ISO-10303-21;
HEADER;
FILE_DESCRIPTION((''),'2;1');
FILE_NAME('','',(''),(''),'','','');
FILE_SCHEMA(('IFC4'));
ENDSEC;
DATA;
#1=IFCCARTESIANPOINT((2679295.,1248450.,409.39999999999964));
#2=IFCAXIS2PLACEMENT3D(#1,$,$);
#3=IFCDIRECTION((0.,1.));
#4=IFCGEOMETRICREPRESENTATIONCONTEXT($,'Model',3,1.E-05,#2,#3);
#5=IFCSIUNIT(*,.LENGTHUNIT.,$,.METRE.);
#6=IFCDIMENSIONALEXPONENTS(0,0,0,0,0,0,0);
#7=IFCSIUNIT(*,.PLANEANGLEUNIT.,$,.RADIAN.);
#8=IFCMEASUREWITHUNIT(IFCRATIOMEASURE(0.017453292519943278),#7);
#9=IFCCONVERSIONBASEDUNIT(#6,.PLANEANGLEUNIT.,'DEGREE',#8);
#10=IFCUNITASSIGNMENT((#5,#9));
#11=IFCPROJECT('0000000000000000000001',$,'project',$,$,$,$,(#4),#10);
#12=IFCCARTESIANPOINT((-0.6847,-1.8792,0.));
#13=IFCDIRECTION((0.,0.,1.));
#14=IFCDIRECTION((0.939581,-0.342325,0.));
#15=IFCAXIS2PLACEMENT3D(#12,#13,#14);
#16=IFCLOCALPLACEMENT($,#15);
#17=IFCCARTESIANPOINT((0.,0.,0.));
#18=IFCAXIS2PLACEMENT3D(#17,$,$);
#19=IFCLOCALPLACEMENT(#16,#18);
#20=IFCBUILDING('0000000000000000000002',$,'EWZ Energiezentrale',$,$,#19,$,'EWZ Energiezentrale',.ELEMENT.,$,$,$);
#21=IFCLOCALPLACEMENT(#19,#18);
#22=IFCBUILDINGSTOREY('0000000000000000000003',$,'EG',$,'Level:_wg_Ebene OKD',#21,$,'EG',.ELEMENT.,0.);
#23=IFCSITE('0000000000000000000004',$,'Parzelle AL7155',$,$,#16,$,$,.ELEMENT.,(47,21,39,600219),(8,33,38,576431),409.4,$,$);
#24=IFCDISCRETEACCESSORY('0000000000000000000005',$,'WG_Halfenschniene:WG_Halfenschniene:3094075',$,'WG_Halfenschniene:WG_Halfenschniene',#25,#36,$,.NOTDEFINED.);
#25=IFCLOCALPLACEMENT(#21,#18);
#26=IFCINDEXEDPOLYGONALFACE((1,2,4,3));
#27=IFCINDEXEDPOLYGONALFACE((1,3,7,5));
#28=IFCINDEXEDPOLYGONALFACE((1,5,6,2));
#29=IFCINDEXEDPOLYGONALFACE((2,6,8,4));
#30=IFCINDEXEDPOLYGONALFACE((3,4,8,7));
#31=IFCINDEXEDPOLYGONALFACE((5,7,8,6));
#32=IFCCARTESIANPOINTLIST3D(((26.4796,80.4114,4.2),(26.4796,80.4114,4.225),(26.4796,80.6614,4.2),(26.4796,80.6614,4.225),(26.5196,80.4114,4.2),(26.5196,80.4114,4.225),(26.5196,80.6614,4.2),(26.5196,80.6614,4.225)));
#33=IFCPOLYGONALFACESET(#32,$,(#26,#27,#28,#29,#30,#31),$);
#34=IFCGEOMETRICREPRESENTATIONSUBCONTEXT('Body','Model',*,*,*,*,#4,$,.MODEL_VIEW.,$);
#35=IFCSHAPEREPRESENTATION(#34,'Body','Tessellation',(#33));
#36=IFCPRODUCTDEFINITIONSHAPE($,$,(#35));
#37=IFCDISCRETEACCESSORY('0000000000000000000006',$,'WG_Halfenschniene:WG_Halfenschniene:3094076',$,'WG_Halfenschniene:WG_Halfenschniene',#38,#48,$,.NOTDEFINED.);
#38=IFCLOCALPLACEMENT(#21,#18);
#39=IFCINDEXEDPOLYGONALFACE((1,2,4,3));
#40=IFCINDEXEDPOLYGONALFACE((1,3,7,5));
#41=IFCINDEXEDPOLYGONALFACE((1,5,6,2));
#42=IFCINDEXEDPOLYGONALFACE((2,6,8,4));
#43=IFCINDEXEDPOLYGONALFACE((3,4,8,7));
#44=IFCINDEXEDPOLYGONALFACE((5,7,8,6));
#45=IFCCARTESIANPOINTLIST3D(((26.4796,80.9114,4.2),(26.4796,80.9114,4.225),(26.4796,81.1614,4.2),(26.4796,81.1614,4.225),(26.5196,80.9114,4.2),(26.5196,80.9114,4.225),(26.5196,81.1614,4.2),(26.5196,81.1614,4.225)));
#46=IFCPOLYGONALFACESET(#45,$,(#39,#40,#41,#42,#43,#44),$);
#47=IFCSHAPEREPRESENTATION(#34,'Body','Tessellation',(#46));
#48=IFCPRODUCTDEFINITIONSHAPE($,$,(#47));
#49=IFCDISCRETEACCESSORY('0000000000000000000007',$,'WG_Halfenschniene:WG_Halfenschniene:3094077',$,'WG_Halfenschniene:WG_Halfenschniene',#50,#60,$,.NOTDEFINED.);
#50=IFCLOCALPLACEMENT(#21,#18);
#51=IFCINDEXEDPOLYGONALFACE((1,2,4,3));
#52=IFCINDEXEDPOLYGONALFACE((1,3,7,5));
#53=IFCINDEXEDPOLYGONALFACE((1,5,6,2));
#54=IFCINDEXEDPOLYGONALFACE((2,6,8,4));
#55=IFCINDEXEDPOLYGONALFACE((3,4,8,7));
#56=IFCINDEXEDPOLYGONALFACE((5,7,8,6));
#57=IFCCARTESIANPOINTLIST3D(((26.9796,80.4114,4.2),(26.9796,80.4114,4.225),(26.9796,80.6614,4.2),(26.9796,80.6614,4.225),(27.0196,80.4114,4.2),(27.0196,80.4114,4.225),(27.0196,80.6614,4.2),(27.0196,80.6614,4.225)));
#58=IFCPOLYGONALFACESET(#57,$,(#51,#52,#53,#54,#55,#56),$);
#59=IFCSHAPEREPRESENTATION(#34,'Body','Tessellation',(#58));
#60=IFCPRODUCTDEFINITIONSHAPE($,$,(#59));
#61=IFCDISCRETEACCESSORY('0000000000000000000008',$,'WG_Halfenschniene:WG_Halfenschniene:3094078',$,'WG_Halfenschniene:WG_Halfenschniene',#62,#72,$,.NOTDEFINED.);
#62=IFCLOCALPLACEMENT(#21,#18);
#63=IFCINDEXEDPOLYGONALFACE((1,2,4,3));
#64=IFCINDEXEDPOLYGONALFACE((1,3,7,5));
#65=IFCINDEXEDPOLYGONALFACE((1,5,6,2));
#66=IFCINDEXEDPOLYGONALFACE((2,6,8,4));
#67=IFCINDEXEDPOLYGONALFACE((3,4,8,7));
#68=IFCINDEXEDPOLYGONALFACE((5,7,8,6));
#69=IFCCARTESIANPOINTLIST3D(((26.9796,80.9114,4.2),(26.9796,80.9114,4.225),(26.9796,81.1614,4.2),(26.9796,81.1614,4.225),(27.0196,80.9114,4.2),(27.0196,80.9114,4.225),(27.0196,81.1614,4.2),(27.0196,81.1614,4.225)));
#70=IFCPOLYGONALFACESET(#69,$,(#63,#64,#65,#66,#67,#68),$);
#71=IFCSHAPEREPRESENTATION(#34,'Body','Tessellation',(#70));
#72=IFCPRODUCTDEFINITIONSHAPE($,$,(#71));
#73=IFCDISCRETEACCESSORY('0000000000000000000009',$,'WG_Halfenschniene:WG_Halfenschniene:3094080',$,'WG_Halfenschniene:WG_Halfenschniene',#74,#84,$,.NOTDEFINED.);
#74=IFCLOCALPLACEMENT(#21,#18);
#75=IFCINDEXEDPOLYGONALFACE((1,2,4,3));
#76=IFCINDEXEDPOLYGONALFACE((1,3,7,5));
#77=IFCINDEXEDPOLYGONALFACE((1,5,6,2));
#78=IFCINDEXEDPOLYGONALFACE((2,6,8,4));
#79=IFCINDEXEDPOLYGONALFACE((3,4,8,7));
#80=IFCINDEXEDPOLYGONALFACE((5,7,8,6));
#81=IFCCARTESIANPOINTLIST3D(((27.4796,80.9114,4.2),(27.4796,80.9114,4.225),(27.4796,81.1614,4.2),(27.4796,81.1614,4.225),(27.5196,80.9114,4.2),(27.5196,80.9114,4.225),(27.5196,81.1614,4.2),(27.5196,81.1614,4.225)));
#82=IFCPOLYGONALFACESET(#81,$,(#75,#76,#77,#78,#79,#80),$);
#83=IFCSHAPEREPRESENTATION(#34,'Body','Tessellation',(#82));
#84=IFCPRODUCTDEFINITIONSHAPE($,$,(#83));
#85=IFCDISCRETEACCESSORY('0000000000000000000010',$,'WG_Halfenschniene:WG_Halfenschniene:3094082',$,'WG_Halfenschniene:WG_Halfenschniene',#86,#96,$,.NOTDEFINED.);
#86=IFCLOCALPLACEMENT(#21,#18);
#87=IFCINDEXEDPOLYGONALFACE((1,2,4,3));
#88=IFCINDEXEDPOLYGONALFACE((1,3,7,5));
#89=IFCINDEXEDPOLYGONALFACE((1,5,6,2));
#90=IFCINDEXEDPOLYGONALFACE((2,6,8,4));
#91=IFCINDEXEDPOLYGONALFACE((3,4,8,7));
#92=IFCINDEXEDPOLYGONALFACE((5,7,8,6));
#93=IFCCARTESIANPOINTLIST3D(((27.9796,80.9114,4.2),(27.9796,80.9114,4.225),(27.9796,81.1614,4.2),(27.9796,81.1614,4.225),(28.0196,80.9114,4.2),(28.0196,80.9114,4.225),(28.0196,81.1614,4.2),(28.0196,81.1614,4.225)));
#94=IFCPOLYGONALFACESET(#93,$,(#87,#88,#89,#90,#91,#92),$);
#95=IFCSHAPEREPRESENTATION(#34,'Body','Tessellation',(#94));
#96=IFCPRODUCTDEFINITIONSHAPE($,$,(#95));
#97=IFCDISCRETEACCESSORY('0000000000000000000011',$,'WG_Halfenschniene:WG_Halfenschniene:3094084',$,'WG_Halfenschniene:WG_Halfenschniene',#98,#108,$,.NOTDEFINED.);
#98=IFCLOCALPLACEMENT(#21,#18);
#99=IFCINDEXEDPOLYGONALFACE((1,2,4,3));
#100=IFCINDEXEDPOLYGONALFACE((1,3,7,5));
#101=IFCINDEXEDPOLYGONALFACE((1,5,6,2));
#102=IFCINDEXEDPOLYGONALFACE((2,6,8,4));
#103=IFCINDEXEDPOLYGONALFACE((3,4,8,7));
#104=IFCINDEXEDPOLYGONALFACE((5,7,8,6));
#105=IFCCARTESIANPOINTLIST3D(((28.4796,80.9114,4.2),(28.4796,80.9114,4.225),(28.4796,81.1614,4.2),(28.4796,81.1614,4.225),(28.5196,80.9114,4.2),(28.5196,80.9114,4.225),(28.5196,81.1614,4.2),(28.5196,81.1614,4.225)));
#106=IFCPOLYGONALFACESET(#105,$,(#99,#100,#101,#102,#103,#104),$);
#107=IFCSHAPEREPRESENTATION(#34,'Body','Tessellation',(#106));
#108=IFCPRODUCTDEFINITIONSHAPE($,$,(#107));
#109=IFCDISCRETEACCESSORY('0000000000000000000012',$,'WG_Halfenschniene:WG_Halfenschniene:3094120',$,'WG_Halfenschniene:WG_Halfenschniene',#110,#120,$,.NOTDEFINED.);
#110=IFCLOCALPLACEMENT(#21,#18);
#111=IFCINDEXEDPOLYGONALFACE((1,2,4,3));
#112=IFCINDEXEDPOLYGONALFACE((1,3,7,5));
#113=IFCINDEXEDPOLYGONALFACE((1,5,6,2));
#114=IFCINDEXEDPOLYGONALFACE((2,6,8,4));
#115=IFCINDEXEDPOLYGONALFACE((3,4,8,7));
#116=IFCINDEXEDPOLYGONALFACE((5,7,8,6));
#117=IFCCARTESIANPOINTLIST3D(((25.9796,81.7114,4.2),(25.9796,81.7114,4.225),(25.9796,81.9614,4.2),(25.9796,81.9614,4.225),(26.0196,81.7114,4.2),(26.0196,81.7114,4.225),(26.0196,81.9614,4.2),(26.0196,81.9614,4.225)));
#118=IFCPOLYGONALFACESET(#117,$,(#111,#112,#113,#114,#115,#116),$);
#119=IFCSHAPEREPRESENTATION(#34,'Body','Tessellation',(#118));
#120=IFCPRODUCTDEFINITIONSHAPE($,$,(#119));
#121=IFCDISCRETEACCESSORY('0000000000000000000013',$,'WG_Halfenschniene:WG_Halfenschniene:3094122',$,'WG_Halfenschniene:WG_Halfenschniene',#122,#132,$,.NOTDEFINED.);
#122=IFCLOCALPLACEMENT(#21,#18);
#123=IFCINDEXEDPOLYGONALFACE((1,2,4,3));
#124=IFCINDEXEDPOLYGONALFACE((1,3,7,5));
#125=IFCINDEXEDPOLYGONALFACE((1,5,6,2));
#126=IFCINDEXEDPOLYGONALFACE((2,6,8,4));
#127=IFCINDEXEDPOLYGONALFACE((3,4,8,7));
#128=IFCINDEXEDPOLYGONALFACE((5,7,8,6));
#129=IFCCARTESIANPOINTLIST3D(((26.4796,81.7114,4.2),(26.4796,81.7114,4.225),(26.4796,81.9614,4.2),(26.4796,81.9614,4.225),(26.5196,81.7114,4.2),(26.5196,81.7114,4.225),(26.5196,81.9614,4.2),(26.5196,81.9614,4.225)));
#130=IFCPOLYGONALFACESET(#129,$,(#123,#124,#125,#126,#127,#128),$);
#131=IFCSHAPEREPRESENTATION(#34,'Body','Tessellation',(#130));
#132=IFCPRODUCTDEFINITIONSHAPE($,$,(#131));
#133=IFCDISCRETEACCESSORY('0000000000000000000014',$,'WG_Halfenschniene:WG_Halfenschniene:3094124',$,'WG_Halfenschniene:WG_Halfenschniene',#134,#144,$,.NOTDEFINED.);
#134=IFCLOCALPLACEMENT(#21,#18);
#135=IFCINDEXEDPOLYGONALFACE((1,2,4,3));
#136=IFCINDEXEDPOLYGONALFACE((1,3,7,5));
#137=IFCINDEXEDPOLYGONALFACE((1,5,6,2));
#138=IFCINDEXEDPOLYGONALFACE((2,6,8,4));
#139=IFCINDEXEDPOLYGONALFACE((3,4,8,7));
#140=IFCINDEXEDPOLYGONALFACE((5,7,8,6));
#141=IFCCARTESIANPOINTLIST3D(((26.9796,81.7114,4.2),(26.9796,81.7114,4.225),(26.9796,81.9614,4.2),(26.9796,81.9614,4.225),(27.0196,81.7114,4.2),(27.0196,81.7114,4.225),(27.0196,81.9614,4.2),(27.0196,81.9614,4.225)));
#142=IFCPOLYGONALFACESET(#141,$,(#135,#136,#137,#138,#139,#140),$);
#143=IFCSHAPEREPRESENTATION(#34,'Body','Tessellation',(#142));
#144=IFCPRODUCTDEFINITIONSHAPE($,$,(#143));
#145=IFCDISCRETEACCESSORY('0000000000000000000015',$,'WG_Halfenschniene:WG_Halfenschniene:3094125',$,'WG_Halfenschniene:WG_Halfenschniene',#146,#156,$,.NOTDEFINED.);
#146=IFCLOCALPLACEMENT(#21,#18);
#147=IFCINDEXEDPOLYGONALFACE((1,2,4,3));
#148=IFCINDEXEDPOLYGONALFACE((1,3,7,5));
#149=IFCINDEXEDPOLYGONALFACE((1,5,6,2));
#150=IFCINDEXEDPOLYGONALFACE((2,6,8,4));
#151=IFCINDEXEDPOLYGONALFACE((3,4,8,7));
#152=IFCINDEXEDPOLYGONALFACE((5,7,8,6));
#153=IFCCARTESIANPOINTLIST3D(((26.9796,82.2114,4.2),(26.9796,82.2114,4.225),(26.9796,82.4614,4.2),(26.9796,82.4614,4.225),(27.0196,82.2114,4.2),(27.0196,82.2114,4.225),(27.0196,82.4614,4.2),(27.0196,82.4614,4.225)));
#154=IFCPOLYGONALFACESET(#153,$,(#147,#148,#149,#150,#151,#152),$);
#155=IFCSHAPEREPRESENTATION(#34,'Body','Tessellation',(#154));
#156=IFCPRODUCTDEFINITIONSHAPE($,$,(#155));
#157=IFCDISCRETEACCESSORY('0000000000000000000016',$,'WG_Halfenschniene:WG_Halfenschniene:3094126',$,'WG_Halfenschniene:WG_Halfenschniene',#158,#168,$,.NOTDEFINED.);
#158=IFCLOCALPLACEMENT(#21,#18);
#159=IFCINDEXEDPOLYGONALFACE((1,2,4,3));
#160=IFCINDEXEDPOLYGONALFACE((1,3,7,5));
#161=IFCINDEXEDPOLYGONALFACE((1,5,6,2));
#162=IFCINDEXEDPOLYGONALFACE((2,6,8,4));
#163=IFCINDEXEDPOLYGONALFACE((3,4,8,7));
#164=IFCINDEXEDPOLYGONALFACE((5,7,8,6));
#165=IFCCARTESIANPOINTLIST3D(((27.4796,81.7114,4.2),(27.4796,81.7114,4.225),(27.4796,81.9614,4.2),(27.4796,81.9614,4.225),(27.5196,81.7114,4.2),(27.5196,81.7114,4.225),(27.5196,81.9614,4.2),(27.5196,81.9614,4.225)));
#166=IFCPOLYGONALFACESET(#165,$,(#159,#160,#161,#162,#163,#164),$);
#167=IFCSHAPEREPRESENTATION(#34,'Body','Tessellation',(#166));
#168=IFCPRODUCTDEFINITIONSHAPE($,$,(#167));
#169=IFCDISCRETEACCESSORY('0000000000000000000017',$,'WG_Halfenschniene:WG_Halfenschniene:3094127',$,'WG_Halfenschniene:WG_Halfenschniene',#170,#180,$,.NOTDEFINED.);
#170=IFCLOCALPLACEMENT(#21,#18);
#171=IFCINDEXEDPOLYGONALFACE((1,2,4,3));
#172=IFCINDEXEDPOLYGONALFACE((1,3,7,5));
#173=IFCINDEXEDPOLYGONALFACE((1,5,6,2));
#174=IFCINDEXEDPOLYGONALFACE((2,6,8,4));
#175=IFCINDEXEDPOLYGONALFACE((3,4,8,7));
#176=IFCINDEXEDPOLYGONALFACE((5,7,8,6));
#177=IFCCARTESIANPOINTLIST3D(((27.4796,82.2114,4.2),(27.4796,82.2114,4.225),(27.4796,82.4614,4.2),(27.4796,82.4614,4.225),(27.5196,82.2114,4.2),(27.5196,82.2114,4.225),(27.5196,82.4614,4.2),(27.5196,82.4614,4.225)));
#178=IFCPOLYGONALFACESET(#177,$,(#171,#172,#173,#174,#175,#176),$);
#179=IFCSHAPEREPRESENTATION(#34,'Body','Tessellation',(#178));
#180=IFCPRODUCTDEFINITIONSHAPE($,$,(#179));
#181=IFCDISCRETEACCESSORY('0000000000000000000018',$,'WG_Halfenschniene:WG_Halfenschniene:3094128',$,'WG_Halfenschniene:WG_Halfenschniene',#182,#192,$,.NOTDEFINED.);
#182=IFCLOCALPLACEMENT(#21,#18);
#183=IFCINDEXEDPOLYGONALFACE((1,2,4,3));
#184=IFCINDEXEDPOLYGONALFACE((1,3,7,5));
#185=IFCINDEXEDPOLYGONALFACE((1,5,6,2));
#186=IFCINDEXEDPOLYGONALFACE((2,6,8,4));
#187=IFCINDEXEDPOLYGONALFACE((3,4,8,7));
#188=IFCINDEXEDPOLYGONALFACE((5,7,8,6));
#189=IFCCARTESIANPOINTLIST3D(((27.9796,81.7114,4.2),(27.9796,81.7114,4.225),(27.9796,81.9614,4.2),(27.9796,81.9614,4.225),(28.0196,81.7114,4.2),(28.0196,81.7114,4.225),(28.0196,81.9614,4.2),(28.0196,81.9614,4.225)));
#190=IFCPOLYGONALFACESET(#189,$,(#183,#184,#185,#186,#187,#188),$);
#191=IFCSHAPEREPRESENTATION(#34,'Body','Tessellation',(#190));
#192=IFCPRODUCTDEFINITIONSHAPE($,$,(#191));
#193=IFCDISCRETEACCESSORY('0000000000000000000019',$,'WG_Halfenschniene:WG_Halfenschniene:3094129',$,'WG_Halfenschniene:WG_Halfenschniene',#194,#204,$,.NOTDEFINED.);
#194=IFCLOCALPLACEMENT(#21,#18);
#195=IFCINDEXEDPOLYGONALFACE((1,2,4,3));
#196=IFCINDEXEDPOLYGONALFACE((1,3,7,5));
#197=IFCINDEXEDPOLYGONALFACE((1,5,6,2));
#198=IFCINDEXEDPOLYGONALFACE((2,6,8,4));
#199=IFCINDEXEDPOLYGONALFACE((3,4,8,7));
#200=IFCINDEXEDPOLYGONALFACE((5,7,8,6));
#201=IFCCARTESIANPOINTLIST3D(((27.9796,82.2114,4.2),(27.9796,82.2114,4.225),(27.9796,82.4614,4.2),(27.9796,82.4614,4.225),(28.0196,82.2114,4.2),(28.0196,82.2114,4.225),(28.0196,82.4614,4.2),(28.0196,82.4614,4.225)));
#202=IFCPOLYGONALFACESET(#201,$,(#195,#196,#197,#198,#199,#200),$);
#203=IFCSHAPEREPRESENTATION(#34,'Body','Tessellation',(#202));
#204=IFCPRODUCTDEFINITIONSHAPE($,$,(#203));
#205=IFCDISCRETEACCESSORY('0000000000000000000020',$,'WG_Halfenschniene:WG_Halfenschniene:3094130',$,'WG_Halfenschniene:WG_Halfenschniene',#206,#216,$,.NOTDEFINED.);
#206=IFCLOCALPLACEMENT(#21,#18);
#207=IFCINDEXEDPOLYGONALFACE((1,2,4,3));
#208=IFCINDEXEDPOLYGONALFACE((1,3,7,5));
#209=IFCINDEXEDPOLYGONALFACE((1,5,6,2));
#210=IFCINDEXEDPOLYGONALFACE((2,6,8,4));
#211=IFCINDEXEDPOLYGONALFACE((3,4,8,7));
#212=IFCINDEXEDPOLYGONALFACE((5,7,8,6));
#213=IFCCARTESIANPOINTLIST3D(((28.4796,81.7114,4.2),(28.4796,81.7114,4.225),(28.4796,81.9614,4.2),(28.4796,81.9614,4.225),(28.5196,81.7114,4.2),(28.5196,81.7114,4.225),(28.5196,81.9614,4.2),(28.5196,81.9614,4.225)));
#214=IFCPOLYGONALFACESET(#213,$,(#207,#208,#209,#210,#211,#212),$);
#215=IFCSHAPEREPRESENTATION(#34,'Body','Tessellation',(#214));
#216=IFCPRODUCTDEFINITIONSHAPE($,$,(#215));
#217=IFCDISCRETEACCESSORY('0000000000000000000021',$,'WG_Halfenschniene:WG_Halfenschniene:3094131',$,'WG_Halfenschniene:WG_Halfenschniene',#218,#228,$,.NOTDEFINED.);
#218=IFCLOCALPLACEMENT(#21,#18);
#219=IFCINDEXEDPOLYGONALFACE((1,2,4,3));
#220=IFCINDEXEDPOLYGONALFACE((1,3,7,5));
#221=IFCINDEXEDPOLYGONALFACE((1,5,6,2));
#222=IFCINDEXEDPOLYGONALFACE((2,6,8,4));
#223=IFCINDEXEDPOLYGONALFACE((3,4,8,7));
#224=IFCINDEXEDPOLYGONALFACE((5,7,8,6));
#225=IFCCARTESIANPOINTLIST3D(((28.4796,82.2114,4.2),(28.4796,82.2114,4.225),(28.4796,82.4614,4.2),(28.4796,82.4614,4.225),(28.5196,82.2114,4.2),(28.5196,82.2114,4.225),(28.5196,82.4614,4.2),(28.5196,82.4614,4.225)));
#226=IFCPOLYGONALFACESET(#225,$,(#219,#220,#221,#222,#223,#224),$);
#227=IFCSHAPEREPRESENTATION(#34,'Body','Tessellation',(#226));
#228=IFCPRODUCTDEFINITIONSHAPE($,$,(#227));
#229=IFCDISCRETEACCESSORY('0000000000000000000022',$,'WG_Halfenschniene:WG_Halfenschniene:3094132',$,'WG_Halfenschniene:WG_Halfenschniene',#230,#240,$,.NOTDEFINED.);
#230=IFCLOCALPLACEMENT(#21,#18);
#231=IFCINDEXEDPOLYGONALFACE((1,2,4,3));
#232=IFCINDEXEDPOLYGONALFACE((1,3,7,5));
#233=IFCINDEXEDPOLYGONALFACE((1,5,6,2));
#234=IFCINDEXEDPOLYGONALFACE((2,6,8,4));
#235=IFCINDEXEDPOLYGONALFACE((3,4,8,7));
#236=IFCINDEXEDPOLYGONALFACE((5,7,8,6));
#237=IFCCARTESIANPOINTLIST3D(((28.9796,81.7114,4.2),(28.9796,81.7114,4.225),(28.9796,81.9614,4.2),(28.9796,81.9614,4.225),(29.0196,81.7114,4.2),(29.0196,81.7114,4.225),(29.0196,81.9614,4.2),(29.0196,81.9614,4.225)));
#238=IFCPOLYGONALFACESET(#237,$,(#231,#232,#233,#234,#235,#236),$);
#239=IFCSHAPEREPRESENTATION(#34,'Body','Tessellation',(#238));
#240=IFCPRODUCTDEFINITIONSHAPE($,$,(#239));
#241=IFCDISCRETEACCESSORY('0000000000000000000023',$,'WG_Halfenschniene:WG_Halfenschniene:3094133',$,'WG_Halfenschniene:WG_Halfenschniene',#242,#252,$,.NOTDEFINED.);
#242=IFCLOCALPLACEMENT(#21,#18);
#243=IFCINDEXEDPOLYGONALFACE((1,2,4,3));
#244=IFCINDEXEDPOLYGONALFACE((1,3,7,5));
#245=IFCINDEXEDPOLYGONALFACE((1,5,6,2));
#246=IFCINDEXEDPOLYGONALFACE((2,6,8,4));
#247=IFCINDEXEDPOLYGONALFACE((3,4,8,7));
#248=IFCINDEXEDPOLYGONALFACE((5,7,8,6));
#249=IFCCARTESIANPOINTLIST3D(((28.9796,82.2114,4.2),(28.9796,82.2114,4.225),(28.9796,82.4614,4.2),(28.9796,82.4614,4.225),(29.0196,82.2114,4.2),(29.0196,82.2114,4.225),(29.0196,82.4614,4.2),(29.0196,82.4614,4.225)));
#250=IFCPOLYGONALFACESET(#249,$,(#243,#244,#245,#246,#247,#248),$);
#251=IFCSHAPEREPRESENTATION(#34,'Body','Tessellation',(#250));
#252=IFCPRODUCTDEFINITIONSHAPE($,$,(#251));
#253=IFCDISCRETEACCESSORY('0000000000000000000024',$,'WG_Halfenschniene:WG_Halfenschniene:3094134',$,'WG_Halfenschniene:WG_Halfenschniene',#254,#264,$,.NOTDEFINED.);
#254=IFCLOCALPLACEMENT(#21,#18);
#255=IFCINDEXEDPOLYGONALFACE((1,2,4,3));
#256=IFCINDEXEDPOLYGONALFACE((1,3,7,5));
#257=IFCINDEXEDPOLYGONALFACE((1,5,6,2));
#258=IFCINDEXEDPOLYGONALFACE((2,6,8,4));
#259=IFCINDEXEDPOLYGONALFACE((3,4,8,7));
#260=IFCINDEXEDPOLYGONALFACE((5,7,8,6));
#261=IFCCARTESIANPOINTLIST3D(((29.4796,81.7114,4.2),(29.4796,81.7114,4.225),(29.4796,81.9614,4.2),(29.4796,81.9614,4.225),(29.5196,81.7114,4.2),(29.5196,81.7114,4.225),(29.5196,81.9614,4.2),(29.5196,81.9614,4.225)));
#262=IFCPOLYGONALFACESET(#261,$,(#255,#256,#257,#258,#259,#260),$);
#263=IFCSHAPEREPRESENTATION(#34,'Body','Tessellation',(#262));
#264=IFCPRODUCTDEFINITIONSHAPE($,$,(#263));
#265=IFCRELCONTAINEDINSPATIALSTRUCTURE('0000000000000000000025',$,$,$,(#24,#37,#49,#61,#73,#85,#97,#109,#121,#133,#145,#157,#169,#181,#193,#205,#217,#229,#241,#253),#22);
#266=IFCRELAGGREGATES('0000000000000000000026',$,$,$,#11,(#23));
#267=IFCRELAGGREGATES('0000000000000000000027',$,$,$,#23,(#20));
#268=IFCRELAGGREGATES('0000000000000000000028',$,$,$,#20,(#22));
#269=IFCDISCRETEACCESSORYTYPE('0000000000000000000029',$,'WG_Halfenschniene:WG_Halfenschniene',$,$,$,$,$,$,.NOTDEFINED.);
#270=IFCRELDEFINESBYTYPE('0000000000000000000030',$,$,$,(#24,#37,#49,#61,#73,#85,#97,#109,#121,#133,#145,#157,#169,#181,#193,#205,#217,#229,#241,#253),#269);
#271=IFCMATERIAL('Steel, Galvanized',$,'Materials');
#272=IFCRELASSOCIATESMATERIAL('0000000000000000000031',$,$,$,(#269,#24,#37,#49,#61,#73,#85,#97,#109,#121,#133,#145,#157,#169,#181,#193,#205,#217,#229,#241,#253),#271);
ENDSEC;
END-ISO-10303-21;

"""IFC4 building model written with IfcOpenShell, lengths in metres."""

from ifc_helpers import new_model, entity, si_unit, converted_unit, direction, frame, origin, place, context, subcontext, project, spatial, indexed_curve, outline, extrude, source, transform, mapped, material, type_object, element, save


model = new_model("IFC4")

# Units and contexts
model_context = context("Model", 3, precision=1e-05, world=frame((2679295.0, 1248450.0, 409.39999999999964)), true_north=direction((0.0, 1.0)))
body_context = subcontext(model_context, "Body", "Model", "MODEL_VIEW")
ifc_project = project(units=[si_unit("LENGTHUNIT", "METRE"), converted_unit("PLANEANGLEUNIT", "DEGREE", entity("IfcRatioMeasure", 0.017453292519943278), si_unit("PLANEANGLEUNIT", "RADIAN"), dimensions=[0, 0, 0, 0, 0, 0, 0])], contexts=[model_context])

# Site, building, storey
site_placement = place(None, frame((-0.6847, -1.8792, 0.0), z_axis=(0.0, 0.0, 1.0), x_axis=(0.939581, -0.342325, 0.0)))
site = spatial("IfcSite", under=ifc_project, at=site_placement, Name="Parzelle AL7155", CompositionType="ELEMENT", RefLatitude=(47, 21, 39, 600219), RefLongitude=(8, 33, 38, 576431), RefElevation=409.4)
building_placement = place(site_placement, origin())
building = spatial("IfcBuilding", under=site, at=building_placement, Name="EWZ Energiezentrale", LongName="EWZ Energiezentrale", CompositionType="ELEMENT")
storey_placement = place(building_placement, origin())
storey = spatial("IfcBuildingStorey", under=building, at=storey_placement, Name="EG", ObjectType="Level:_wg_Ebene OKD", LongName="EG", CompositionType="ELEMENT", Elevation=0.0)

# Discrete accessories
ifc_material = material(Name="Steel, Galvanized", Category="Materials")
discrete_accessory_type = type_object("IfcDiscreteAccessoryType", Name="WG_Halfenschniene:WG_Halfenschniene", PredefinedType="NOTDEFINED", material=ifc_material)
shared_shape = source(origin(), body_context, "Body", "SweptSolid", [
    extrude(outline(indexed_curve([(-0.125, -0.02), (0.125, -0.02), (0.125, 0.02), (-0.125, 0.02), (-0.125, -0.02)], self_intersect=False)), frame((0.125, 0.0, -0.0125)), (0.0, 0.0, 1.0), 0.025),
])
for number, where, z_axis, x_axis, name in (
    (1, (26.4996, 80.4114, 4.2125), (0.0, 0.0, -1.0), (0.0, 1.0, 0.0), "WG_Halfenschniene:WG_Halfenschniene:3094075"),
    (2, (26.4996, 80.9114, 4.2125), (0.0, 0.0, -1.0), (0.0, 1.0, 0.0), "WG_Halfenschniene:WG_Halfenschniene:3094076"),
    (3, (26.9996, 80.4114, 4.2125), (0.0, 0.0, -1.0), (0.0, 1.0, 0.0), "WG_Halfenschniene:WG_Halfenschniene:3094077"),
    (4, (26.9996, 80.9114, 4.2125), (0.0, 0.0, -1.0), (0.0, 1.0, 0.0), "WG_Halfenschniene:WG_Halfenschniene:3094078"),
    (5, (27.4996, 80.9114, 4.2125), (0.0, 0.0, -1.0), (0.0, 1.0, 0.0), "WG_Halfenschniene:WG_Halfenschniene:3094080"),
    (6, (27.9996, 80.9114, 4.2125), (0.0, 0.0, -1.0), (0.0, 1.0, 0.0), "WG_Halfenschniene:WG_Halfenschniene:3094082"),
    (7, (28.4996, 80.9114, 4.2125), (0.0, 0.0, -1.0), (0.0, 1.0, 0.0), "WG_Halfenschniene:WG_Halfenschniene:3094084"),
    (8, (25.9996, 81.7114, 4.2125), (0.0, 0.0, -1.0), (0.0, 1.0, 0.0), "WG_Halfenschniene:WG_Halfenschniene:3094120"),
    (9, (26.4996, 81.7114, 4.2125), (0.0, 0.0, -1.0), (0.0, 1.0, 0.0), "WG_Halfenschniene:WG_Halfenschniene:3094122"),
    (10, (26.9996, 81.7114, 4.2125), (0.0, 0.0, -1.0), (0.0, 1.0, 0.0), "WG_Halfenschniene:WG_Halfenschniene:3094124"),
    (11, (26.9996, 82.2114, 4.2125), (0.0, 0.0, -1.0), (0.0, 1.0, 0.0), "WG_Halfenschniene:WG_Halfenschniene:3094125"),
    (12, (27.4996, 81.7114, 4.2125), (0.0, 0.0, -1.0), (0.0, 1.0, 0.0), "WG_Halfenschniene:WG_Halfenschniene:3094126"),
    (13, (27.4996, 82.2114, 4.2125), (0.0, 0.0, -1.0), (0.0, 1.0, 0.0), "WG_Halfenschniene:WG_Halfenschniene:3094127"),
    (14, (27.9996, 81.7114, 4.2125), (0.0, 0.0, -1.0), (0.0, 1.0, 0.0), "WG_Halfenschniene:WG_Halfenschniene:3094128"),
    (15, (27.9996, 82.2114, 4.2125), (0.0, 0.0, -1.0), (0.0, 1.0, 0.0), "WG_Halfenschniene:WG_Halfenschniene:3094129"),
    (16, (28.4996, 81.7114, 4.2125), (0.0, 0.0, -1.0), (0.0, 1.0, 0.0), "WG_Halfenschniene:WG_Halfenschniene:3094130"),
    (17, (28.4996, 82.2114, 4.2125), (0.0, 0.0, -1.0), (0.0, 1.0, 0.0), "WG_Halfenschniene:WG_Halfenschniene:3094131"),
    (18, (28.9996, 81.7114, 4.2125), (0.0, 0.0, -1.0), (0.0, 1.0, 0.0), "WG_Halfenschniene:WG_Halfenschniene:3094132"),
    (19, (28.9996, 82.2114, 4.2125), (0.0, 0.0, -1.0), (0.0, 1.0, 0.0), "WG_Halfenschniene:WG_Halfenschniene:3094133"),
    (20, (29.4996, 81.7114, 4.2125), (0.0, 0.0, -1.0), (0.0, 1.0, 0.0), "WG_Halfenschniene:WG_Halfenschniene:3094134"),
):
    element("IfcDiscreteAccessory", number, at=place(storey_placement, frame(where, z_axis=z_axis, x_axis=x_axis)), inside=storey, type_object=discrete_accessory_type, material=ifc_material, Name=name, ObjectType="WG_Halfenschniene:WG_Halfenschniene", PredefinedType="NOTDEFINED", context=body_context, shape_type="MappedRepresentation", body=[
        mapped(shared_shape, transform((0.0, 0.0, 0.0), scale=1.0)),
    ])

save(model, "model.ifc")
